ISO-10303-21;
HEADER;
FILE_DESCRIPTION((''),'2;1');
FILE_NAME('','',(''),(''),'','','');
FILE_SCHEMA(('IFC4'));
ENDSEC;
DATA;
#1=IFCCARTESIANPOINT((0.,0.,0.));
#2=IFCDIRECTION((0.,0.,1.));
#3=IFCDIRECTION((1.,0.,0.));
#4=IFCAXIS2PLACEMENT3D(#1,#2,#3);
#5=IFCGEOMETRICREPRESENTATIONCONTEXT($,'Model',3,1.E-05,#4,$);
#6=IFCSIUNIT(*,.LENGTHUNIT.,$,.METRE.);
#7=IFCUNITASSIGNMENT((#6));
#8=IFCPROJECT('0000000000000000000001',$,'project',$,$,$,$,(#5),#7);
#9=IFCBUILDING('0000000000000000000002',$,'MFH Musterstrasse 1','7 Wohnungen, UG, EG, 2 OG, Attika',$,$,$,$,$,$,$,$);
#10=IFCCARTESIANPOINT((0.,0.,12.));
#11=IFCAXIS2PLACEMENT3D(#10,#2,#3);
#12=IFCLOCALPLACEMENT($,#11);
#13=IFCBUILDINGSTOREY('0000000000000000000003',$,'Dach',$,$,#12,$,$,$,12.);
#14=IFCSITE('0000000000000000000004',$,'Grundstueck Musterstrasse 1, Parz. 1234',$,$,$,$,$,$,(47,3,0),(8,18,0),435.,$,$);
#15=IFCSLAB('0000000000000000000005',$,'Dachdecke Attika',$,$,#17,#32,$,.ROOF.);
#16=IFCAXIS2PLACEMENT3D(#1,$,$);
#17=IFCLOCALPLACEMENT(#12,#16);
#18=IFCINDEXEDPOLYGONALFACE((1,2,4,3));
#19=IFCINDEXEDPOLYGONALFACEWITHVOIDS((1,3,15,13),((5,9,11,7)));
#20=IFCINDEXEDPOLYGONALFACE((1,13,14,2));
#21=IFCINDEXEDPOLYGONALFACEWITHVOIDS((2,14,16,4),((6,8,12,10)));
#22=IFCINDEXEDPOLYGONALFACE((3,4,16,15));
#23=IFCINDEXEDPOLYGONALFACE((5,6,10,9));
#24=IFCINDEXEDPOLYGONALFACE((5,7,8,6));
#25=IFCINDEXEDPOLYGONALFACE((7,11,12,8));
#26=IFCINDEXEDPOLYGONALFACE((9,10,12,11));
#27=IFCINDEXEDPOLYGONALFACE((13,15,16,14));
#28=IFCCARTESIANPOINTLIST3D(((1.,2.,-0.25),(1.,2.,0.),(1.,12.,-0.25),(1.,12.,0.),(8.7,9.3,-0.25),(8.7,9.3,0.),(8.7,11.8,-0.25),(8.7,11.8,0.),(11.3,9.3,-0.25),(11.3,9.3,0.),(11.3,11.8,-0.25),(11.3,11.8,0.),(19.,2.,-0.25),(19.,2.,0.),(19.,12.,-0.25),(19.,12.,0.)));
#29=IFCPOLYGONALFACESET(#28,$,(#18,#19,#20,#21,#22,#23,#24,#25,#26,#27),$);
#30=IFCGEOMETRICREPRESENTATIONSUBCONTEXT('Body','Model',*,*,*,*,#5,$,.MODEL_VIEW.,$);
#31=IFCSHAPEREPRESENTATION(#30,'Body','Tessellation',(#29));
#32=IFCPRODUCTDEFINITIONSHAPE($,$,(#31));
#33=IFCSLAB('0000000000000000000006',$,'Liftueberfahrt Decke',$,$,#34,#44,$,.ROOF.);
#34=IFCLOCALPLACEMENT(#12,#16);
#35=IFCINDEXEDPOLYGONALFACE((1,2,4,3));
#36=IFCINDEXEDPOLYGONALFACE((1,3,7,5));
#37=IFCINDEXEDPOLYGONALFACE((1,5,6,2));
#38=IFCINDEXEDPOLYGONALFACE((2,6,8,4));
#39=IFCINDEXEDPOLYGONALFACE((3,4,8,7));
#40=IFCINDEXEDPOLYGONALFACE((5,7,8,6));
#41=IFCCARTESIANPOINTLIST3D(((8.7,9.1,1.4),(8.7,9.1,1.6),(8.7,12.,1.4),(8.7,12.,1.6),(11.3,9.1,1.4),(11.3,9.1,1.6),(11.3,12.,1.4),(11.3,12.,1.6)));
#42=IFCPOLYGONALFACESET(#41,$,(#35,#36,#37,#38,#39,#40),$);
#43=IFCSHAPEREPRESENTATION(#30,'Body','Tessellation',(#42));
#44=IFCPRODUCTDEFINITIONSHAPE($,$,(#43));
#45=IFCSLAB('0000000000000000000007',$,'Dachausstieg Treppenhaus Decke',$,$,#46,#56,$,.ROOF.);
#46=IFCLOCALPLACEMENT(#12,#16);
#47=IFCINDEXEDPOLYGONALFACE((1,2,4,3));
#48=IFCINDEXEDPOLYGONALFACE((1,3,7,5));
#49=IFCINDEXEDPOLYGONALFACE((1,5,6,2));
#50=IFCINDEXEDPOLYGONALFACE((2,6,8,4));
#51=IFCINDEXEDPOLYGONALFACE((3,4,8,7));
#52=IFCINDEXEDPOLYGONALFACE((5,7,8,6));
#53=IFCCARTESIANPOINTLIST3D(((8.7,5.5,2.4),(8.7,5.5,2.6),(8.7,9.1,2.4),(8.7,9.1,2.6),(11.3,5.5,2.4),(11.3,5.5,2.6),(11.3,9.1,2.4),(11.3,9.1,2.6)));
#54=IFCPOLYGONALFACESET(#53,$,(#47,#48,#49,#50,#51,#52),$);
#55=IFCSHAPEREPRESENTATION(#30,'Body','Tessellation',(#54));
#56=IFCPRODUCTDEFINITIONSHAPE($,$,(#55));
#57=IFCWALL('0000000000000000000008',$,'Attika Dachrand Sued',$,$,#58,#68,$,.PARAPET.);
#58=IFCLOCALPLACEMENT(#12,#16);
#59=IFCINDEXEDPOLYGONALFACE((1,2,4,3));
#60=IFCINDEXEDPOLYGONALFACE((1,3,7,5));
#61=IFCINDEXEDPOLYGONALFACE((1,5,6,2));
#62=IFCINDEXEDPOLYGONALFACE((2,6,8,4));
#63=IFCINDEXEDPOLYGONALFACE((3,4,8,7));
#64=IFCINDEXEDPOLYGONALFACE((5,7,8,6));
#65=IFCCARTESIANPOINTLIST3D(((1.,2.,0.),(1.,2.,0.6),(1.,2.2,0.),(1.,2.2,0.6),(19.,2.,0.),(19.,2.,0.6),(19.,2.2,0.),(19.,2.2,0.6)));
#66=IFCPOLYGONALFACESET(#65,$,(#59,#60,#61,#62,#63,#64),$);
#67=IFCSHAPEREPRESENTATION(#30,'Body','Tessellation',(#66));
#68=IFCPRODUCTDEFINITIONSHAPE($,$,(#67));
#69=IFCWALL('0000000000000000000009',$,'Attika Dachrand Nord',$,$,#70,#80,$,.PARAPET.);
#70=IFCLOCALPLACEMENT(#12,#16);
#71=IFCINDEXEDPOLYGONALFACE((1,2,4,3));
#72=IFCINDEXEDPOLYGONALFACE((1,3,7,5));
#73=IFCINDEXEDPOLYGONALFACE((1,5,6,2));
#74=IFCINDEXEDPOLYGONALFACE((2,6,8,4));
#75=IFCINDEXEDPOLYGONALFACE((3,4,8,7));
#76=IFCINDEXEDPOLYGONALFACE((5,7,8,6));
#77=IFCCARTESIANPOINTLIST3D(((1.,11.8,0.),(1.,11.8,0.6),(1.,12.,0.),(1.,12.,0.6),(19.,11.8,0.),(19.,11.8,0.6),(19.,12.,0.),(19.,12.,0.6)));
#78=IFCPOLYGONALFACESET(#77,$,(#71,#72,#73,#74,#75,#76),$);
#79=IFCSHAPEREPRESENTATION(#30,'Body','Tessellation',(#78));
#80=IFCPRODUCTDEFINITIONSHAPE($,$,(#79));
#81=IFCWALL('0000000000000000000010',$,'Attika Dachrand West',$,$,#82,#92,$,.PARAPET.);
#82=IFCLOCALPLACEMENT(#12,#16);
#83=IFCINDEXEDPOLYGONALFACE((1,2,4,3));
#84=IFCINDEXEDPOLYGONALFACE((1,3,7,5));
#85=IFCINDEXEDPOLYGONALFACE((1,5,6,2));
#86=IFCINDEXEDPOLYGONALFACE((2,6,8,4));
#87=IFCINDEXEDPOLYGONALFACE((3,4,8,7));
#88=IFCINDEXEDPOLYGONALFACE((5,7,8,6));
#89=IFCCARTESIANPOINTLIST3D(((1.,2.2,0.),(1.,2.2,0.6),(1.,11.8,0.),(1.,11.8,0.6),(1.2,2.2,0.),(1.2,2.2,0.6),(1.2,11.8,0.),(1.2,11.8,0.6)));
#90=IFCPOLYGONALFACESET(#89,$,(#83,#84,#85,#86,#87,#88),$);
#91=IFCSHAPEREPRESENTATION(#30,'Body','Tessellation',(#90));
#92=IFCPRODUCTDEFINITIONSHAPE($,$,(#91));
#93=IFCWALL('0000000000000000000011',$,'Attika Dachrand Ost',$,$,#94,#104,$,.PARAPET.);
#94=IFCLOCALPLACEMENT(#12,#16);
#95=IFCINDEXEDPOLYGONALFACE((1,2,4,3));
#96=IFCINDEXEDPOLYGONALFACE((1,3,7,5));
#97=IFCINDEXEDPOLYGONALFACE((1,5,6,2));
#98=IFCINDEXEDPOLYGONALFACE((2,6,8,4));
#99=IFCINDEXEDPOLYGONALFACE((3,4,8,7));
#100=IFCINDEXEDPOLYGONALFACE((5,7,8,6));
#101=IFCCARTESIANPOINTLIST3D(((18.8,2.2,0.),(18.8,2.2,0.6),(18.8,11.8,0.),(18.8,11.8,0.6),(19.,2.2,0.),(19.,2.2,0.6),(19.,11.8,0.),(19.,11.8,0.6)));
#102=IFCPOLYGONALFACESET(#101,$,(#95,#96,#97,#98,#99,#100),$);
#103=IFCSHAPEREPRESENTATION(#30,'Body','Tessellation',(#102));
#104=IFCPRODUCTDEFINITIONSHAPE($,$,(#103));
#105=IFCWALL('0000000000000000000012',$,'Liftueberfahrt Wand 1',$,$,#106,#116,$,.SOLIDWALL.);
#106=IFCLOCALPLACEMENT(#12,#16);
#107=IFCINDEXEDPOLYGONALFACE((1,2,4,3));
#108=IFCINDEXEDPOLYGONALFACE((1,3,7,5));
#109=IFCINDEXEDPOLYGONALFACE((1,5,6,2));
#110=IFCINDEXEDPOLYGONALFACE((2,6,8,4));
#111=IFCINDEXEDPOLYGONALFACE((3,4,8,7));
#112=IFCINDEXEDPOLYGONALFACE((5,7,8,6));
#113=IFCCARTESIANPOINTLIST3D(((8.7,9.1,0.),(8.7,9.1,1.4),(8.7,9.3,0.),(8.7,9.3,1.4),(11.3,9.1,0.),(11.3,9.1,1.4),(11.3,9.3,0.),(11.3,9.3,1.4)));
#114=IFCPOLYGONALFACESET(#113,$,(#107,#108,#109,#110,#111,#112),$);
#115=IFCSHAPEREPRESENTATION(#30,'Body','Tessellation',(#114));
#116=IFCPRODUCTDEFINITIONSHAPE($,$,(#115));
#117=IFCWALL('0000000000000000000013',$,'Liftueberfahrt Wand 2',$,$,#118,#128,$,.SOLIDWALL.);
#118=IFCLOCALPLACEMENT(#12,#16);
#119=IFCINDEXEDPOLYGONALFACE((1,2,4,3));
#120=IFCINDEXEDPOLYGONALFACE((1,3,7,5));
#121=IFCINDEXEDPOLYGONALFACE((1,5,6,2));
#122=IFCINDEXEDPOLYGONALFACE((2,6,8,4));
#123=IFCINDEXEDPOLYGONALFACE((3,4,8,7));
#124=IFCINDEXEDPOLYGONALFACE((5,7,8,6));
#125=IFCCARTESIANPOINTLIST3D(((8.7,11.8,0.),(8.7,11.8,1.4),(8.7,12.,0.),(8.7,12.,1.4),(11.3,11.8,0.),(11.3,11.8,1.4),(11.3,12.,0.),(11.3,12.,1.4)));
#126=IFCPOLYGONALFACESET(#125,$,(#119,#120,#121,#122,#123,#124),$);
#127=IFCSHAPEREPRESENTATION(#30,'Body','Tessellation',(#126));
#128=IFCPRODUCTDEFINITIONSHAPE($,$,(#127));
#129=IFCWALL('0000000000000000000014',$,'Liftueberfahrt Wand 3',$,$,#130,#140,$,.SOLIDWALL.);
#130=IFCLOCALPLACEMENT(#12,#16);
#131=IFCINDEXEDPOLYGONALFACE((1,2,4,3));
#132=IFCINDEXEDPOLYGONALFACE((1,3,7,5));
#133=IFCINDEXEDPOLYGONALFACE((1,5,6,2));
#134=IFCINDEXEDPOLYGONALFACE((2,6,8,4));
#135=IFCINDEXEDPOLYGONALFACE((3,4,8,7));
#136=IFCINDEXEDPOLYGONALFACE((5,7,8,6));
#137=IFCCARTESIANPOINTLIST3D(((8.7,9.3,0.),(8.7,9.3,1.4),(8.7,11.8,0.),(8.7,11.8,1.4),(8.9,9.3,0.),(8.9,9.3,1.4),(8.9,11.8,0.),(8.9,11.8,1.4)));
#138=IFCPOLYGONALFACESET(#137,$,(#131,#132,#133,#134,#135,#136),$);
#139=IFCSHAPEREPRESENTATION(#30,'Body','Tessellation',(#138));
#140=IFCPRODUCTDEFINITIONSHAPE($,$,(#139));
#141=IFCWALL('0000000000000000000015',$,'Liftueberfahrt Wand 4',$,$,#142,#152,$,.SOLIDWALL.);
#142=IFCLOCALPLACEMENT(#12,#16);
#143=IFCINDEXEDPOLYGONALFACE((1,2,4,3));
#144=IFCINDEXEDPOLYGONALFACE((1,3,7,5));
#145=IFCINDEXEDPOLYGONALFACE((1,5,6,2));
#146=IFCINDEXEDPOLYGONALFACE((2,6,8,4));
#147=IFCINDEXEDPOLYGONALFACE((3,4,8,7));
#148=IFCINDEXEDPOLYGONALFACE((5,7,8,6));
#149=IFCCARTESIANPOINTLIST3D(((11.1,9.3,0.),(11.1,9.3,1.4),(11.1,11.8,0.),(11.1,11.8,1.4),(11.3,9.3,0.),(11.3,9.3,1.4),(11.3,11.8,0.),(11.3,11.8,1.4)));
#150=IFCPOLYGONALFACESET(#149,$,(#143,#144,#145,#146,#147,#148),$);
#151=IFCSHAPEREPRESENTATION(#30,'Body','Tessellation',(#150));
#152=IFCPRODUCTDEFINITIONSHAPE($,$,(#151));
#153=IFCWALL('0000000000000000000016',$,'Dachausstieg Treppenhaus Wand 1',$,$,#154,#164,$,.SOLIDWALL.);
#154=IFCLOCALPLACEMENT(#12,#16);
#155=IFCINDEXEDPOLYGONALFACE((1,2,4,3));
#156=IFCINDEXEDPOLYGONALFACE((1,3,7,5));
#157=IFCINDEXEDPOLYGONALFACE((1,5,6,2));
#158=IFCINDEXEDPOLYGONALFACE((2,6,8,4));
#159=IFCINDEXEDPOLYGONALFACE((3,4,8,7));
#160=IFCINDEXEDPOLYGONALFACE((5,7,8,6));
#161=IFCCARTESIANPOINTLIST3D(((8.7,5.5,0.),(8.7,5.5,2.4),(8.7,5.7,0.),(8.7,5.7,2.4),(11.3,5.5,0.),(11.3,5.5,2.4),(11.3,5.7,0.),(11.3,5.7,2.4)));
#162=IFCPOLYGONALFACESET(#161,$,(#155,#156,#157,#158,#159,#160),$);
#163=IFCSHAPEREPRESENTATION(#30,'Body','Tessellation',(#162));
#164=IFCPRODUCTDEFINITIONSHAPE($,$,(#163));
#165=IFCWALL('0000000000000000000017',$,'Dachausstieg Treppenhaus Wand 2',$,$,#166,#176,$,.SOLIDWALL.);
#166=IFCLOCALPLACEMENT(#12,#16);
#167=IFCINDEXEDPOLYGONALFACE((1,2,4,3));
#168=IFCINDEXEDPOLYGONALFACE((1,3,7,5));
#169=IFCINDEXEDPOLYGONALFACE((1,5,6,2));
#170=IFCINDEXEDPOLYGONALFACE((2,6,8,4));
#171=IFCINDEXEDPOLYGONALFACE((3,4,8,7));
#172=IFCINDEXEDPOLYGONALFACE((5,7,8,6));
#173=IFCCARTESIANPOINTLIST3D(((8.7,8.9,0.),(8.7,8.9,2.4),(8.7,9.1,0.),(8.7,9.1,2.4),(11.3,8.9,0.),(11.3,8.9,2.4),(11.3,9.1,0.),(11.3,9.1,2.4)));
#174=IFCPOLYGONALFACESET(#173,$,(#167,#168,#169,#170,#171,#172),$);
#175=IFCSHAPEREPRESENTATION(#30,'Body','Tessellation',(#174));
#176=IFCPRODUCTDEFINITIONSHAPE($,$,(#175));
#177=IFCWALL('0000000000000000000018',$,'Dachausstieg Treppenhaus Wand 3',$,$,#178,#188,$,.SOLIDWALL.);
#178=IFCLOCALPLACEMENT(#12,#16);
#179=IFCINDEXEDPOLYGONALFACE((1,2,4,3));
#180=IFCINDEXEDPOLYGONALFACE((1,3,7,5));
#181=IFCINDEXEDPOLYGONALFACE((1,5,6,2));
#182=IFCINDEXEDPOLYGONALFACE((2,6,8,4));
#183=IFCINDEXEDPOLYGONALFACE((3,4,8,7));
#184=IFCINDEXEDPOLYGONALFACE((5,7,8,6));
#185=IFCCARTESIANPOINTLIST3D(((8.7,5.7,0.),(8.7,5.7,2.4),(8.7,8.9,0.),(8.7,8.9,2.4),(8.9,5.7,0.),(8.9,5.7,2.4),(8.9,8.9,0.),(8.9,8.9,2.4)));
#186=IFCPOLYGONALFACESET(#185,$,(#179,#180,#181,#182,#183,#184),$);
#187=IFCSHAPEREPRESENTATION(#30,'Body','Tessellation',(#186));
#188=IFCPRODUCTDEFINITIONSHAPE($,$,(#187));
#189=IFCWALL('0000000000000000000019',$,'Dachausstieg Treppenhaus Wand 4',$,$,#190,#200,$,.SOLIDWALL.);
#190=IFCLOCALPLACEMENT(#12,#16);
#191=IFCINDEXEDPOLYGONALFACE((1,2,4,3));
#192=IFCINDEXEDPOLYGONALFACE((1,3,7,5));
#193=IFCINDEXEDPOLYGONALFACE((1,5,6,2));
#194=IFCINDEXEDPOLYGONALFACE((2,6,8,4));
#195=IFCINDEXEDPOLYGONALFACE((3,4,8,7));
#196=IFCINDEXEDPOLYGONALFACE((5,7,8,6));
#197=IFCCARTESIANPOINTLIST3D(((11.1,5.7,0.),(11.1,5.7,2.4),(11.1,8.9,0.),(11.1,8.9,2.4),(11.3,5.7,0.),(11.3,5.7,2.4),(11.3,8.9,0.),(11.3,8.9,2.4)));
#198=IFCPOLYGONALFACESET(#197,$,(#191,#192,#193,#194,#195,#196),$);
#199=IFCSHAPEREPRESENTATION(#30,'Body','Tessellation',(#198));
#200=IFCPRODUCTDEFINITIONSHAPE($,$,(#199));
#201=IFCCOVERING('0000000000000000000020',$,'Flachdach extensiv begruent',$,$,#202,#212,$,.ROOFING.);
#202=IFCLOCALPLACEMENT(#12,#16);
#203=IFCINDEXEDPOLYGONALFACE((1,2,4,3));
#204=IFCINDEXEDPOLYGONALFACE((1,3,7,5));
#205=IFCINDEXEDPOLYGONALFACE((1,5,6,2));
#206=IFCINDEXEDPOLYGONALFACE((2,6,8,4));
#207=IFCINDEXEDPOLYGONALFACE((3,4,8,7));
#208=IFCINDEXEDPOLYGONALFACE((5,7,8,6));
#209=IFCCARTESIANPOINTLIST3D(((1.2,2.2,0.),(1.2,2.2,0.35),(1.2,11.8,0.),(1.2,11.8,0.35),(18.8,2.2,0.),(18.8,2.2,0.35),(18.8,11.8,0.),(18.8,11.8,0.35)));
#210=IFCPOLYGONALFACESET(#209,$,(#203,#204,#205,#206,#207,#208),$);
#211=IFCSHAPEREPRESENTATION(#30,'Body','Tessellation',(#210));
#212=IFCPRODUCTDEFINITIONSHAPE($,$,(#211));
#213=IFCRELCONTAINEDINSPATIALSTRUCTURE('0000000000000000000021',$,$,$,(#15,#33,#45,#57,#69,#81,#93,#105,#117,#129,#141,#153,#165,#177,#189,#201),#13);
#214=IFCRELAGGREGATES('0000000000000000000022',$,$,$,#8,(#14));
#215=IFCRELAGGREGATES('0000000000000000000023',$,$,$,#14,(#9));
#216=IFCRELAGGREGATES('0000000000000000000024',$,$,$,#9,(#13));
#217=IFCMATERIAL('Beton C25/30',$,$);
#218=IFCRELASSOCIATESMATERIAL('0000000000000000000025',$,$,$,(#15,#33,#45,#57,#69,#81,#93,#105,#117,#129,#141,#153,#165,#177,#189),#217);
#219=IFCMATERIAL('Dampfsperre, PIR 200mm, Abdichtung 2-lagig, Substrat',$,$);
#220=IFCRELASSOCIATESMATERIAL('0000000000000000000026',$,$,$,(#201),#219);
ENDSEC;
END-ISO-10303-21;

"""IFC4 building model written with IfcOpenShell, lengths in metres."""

from ifc_helpers import new_model, si_unit, frame, frame_2d, origin_with_axes, place, context, subcontext, project, spatial, polyline, rectangle, outline, extrude, material, element, save


model = new_model("IFC4")

# Units and contexts
model_context = context("Model", 3, precision=1e-05, world=origin_with_axes())
body_context = subcontext(model_context, "Body", "Model", "MODEL_VIEW")
ifc_project = project(units=[si_unit("LENGTHUNIT", "METRE")], contexts=[model_context])

# Site, building, storey
site = spatial("IfcSite", under=ifc_project, Name="Grundstueck Musterstrasse 1, Parz. 1234", RefLatitude=(47, 3, 0), RefLongitude=(8, 18, 0), RefElevation=435.0)
building = spatial("IfcBuilding", under=site, Name="MFH Musterstrasse 1", Description="7 Wohnungen, UG, EG, 2 OG, Attika")
storey_placement = place(None, frame((0.0, 0.0, 12.0), z_axis=(0.0, 0.0, 1.0), x_axis=(1.0, 0.0, 0.0)))
storey = spatial("IfcBuildingStorey", under=building, at=storey_placement, Name="Dach", Elevation=12.0)

# Slab, opening
ifc_material_1 = material(Name="Beton C25/30")
slab_1_placement = place(storey_placement, frame((0.0, 0.0, -0.25), z_axis=(0.0, 0.0, 1.0), x_axis=(1.0, 0.0, 0.0)))
slab_1 = element("IfcSlab", 1, at=slab_1_placement, inside=storey, material=ifc_material_1, Name="Dachdecke Attika", PredefinedType="ROOF", context=body_context, shape_type="SweptSolid", body=[
    extrude(outline(polyline([(1.0, 2.0), (19.0, 2.0), (19.0, 12.0), (1.0, 12.0), (1.0, 2.0)])), origin_with_axes(), (0.0, 0.0, 1.0), 0.25),
])
opening_placement = place(slab_1_placement, frame((8.7, 9.3, -0.01), z_axis=(0.0, 0.0, 1.0), x_axis=(1.0, 0.0, 0.0)))
element("IfcOpeningElement", 2, at=opening_placement, cuts=slab_1, context=body_context, shape_type="SweptSolid", body=[
    extrude(rectangle(XDim=2.6, YDim=2.5, at=frame_2d((1.3, 1.25))), origin_with_axes(), (0.0, 0.0, 1.0), 0.27),
])

# Slabs
slab_2_placement = place(storey_placement, frame((0.0, 0.0, 1.4), z_axis=(0.0, 0.0, 1.0), x_axis=(1.0, 0.0, 0.0)))
element("IfcSlab", 3, at=slab_2_placement, inside=storey, material=ifc_material_1, Name="Liftueberfahrt Decke", PredefinedType="ROOF", context=body_context, shape_type="SweptSolid", body=[
    extrude(outline(polyline([(8.7, 9.1), (11.3, 9.1), (11.3, 12.0), (8.7, 12.0), (8.7, 9.1)])), origin_with_axes(), (0.0, 0.0, 1.0), 0.2),
])
slab_3_placement = place(storey_placement, frame((0.0, 0.0, 2.4), z_axis=(0.0, 0.0, 1.0), x_axis=(1.0, 0.0, 0.0)))
element("IfcSlab", 4, at=slab_3_placement, inside=storey, material=ifc_material_1, Name="Dachausstieg Treppenhaus Decke", PredefinedType="ROOF", context=body_context, shape_type="SweptSolid", body=[
    extrude(outline(polyline([(8.7, 5.5), (11.3, 5.5), (11.3, 9.1), (8.7, 9.1), (8.7, 5.5)])), origin_with_axes(), (0.0, 0.0, 1.0), 0.2),
])

# Walls
for number, where, z_axis, x_axis, name in (
    (5, (1.0, 2.0, 0.0), (0.0, 0.0, 1.0), (1.0, 0.0, 0.0), "Attika Dachrand Sued"),
    (6, (1.0, 11.8, 0.0), (0.0, 0.0, 1.0), (1.0, 0.0, 0.0), "Attika Dachrand Nord"),
):
    element("IfcWall", number, at=place(storey_placement, frame(where, z_axis=z_axis, x_axis=x_axis)), inside=storey, material=ifc_material_1, Name=name, PredefinedType="PARAPET", context=body_context, shape_type="SweptSolid", body=[
        extrude(rectangle(XDim=18.0, YDim=0.2, at=frame_2d((9.0, 0.1))), origin_with_axes(), (0.0, 0.0, 1.0), 0.6),
    ])
for number, where, z_axis, x_axis, name in (
    (7, (1.0, 2.2, 0.0), (0.0, 0.0, 1.0), (1.0, 0.0, 0.0), "Attika Dachrand West"),
    (8, (18.8, 2.2, 0.0), (0.0, 0.0, 1.0), (1.0, 0.0, 0.0), "Attika Dachrand Ost"),
):
    element("IfcWall", number, at=place(storey_placement, frame(where, z_axis=z_axis, x_axis=x_axis)), inside=storey, material=ifc_material_1, Name=name, PredefinedType="PARAPET", context=body_context, shape_type="SweptSolid", body=[
        extrude(rectangle(XDim=0.2, YDim=9.6, at=frame_2d((0.1, 4.8))), origin_with_axes(), (0.0, 0.0, 1.0), 0.6),
    ])
for number, where, z_axis, x_axis, name in (
    (9, (8.7, 9.1, 0.0), (0.0, 0.0, 1.0), (1.0, 0.0, 0.0), "Liftueberfahrt Wand 1"),
    (10, (8.7, 11.8, 0.0), (0.0, 0.0, 1.0), (1.0, 0.0, 0.0), "Liftueberfahrt Wand 2"),
):
    element("IfcWall", number, at=place(storey_placement, frame(where, z_axis=z_axis, x_axis=x_axis)), inside=storey, material=ifc_material_1, Name=name, PredefinedType="SOLIDWALL", context=body_context, shape_type="SweptSolid", body=[
        extrude(rectangle(XDim=2.6, YDim=0.2, at=frame_2d((1.3, 0.1))), origin_with_axes(), (0.0, 0.0, 1.0), 1.4),
    ])
for number, where, z_axis, x_axis, name in (
    (11, (8.7, 9.3, 0.0), (0.0, 0.0, 1.0), (1.0, 0.0, 0.0), "Liftueberfahrt Wand 3"),
    (12, (11.1, 9.3, 0.0), (0.0, 0.0, 1.0), (1.0, 0.0, 0.0), "Liftueberfahrt Wand 4"),
):
    element("IfcWall", number, at=place(storey_placement, frame(where, z_axis=z_axis, x_axis=x_axis)), inside=storey, material=ifc_material_1, Name=name, PredefinedType="SOLIDWALL", context=body_context, shape_type="SweptSolid", body=[
        extrude(rectangle(XDim=0.2, YDim=2.5, at=frame_2d((0.1, 1.25))), origin_with_axes(), (0.0, 0.0, 1.0), 1.4),
    ])
for number, where, z_axis, x_axis, name in (
    (13, (8.7, 5.5, 0.0), (0.0, 0.0, 1.0), (1.0, 0.0, 0.0), "Dachausstieg Treppenhaus Wand 1"),
    (14, (8.7, 8.9, 0.0), (0.0, 0.0, 1.0), (1.0, 0.0, 0.0), "Dachausstieg Treppenhaus Wand 2"),
):
    element("IfcWall", number, at=place(storey_placement, frame(where, z_axis=z_axis, x_axis=x_axis)), inside=storey, material=ifc_material_1, Name=name, PredefinedType="SOLIDWALL", context=body_context, shape_type="SweptSolid", body=[
        extrude(rectangle(XDim=2.6, YDim=0.2, at=frame_2d((1.3, 0.1))), origin_with_axes(), (0.0, 0.0, 1.0), 2.4),
    ])
for number, where, z_axis, x_axis, name in (
    (15, (8.7, 5.7, 0.0), (0.0, 0.0, 1.0), (1.0, 0.0, 0.0), "Dachausstieg Treppenhaus Wand 3"),
    (16, (11.1, 5.7, 0.0), (0.0, 0.0, 1.0), (1.0, 0.0, 0.0), "Dachausstieg Treppenhaus Wand 4"),
):
    element("IfcWall", number, at=place(storey_placement, frame(where, z_axis=z_axis, x_axis=x_axis)), inside=storey, material=ifc_material_1, Name=name, PredefinedType="SOLIDWALL", context=body_context, shape_type="SweptSolid", body=[
        extrude(rectangle(XDim=0.2, YDim=3.2, at=frame_2d((0.1, 1.6))), origin_with_axes(), (0.0, 0.0, 1.0), 2.4),
    ])

# Covering
ifc_material_2 = material(Name="Dampfsperre, PIR 200mm, Abdichtung 2-lagig, Substrat")
covering_placement = place(storey_placement, origin_with_axes())
element("IfcCovering", 17, at=covering_placement, inside=storey, material=ifc_material_2, Name="Flachdach extensiv begruent", PredefinedType="ROOFING", context=body_context, shape_type="SweptSolid", body=[
    extrude(outline(polyline([(1.2, 2.2), (18.8, 2.2), (18.8, 11.8), (1.2, 11.8), (1.2, 2.2)])), origin_with_axes(), (0.0, 0.0, 1.0), 0.35),
])

save(model, "model.ifc")
